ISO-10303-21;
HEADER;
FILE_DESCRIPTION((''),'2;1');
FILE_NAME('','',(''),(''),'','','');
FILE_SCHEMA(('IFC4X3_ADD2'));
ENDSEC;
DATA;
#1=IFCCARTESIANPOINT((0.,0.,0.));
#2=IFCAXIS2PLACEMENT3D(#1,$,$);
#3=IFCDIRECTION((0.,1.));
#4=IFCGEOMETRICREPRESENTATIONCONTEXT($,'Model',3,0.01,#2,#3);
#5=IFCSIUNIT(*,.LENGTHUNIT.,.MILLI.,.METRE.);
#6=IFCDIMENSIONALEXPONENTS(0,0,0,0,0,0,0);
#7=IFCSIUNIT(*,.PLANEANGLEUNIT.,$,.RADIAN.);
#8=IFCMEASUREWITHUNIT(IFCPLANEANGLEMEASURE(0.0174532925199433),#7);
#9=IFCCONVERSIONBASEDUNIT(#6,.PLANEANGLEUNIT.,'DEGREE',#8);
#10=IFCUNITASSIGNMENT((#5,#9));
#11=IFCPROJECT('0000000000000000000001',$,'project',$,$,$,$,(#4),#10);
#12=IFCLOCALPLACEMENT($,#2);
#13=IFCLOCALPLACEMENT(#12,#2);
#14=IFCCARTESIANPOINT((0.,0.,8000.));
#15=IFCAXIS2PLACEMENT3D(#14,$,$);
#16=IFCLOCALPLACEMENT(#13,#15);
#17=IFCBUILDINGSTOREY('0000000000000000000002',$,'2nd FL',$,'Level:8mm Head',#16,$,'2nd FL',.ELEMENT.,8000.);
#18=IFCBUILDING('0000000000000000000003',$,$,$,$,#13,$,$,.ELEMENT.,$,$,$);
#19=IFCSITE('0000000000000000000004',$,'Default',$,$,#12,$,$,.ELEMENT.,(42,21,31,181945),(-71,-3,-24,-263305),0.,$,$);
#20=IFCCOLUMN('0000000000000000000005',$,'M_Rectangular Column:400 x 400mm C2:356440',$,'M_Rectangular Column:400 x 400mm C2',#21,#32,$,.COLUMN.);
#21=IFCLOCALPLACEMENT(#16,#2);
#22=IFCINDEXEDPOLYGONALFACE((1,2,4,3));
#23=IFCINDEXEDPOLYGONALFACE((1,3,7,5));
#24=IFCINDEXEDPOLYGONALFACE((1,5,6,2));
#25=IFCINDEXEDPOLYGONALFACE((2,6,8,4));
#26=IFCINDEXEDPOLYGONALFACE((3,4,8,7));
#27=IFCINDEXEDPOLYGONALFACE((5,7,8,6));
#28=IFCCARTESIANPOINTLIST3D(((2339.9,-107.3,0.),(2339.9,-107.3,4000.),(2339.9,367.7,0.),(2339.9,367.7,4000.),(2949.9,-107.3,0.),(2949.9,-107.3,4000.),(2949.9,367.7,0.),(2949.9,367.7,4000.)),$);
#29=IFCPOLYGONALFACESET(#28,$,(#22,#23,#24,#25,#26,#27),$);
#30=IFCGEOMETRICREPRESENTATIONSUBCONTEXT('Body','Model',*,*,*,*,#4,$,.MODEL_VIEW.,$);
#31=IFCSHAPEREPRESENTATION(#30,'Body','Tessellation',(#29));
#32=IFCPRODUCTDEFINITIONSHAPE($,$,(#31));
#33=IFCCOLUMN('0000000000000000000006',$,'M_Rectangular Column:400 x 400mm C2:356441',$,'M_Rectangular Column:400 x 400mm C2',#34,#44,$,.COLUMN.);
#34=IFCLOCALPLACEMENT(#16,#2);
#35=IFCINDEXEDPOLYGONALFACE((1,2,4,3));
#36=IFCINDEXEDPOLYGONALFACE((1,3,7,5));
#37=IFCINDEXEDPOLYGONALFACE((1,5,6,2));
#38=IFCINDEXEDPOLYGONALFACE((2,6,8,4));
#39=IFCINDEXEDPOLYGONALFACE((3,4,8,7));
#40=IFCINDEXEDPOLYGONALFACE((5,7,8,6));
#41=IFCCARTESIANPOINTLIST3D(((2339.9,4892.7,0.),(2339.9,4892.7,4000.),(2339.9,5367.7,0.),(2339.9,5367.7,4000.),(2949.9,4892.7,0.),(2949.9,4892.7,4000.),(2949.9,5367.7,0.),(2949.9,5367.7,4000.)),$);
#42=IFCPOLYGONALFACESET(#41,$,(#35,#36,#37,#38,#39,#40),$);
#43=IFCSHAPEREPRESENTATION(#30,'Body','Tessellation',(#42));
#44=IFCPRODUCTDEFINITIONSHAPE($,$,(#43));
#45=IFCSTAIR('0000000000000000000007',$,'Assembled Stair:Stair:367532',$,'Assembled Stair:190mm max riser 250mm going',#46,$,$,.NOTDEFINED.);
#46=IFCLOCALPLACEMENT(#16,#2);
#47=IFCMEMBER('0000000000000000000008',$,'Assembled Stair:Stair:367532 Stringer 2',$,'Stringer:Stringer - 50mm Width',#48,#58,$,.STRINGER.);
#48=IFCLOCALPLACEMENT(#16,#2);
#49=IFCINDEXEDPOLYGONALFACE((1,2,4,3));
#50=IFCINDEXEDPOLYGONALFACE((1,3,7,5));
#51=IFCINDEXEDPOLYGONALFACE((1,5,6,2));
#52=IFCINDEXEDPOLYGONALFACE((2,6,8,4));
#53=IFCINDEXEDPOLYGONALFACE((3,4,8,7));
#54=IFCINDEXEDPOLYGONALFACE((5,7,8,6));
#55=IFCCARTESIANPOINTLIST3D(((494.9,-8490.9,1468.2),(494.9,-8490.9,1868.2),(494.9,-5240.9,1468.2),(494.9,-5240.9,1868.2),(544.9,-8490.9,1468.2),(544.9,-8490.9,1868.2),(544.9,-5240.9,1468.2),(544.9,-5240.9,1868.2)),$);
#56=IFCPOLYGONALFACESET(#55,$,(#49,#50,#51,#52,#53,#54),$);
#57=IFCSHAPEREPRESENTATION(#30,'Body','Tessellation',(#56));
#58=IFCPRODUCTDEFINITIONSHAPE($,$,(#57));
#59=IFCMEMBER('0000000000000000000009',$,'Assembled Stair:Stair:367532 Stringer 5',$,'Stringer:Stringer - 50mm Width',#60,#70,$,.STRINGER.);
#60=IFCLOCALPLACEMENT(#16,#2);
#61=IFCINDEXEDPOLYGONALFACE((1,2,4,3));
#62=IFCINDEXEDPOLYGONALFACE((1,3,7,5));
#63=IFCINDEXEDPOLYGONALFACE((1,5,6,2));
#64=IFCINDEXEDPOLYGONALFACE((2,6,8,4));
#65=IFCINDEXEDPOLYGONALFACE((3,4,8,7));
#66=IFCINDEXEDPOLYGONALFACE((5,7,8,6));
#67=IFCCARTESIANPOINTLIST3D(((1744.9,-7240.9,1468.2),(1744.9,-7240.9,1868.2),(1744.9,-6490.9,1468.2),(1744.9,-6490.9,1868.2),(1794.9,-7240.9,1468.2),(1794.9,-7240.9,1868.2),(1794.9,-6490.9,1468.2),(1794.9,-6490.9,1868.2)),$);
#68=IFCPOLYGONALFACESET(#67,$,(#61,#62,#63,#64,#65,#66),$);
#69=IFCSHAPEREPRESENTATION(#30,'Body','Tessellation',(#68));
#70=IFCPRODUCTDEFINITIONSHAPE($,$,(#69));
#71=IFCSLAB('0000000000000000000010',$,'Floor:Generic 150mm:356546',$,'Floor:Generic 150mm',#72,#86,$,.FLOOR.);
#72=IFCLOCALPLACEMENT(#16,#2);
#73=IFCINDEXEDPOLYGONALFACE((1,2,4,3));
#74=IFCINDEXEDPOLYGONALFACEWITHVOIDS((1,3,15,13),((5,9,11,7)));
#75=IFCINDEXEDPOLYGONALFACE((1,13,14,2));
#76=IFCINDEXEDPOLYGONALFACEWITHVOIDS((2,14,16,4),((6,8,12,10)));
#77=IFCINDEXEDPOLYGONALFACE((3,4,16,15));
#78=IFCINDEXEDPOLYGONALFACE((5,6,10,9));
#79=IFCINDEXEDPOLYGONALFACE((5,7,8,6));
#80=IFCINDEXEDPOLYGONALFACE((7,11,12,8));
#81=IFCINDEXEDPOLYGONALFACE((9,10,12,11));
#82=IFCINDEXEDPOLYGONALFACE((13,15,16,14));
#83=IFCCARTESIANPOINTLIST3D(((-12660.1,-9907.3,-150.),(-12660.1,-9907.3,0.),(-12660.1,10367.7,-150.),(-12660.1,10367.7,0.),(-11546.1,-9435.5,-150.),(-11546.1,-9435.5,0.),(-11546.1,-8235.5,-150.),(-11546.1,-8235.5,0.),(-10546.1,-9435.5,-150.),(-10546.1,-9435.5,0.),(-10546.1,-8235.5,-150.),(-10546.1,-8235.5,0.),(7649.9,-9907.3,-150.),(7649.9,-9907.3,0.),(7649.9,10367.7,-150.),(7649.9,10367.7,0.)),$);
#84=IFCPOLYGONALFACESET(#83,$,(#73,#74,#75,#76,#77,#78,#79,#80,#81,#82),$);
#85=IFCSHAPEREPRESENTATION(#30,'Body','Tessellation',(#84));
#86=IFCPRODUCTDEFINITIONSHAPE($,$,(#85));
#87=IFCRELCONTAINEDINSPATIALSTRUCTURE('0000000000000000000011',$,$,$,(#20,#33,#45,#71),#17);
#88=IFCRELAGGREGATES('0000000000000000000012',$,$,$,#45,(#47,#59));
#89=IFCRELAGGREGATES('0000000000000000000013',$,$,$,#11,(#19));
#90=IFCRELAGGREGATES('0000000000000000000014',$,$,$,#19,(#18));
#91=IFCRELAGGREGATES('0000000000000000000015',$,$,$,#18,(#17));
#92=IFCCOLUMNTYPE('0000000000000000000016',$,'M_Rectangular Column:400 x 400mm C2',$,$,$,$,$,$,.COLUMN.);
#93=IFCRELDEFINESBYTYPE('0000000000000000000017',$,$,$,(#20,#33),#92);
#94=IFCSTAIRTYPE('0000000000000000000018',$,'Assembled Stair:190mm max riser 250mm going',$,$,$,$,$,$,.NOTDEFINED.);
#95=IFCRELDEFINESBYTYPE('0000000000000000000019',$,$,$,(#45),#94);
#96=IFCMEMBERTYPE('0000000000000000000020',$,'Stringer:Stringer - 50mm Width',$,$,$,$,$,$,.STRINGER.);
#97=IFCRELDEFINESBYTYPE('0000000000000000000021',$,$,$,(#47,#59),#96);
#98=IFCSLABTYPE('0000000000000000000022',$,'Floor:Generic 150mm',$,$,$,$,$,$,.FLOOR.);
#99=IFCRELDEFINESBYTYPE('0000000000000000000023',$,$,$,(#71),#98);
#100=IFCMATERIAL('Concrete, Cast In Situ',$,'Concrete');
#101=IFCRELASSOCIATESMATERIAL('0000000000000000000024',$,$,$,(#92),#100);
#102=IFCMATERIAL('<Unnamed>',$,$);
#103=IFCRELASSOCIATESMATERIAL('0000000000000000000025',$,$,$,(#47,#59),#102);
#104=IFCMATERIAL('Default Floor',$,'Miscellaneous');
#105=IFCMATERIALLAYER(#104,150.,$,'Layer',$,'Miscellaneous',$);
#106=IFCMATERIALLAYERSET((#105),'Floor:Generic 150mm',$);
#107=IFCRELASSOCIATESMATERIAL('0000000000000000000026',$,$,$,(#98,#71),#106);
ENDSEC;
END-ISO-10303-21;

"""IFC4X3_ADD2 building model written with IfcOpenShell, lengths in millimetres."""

from ifc_helpers import new_model, entity, si_unit, converted_unit, direction, frame, frame_2d, origin, origin_2d_with_axis, place, context, subcontext, project, spatial, rectangle, extrude, boolean, source, transform, mapped, material, layer, layer_set, layer_usage, material_profile, profile_set, type_object, type_shapes, element, aggregate, save


model = new_model("IFC4X3_ADD2")

# Units and contexts
model_context = context("Model", 3, precision=0.01, world=origin(), true_north=direction((0.0, 1.0)))
body_context = subcontext(model_context, "Body", "Model", "MODEL_VIEW")
ifc_project = project(units=[si_unit("LENGTHUNIT", "METRE", prefix="MILLI"), converted_unit("PLANEANGLEUNIT", "DEGREE", entity("IfcPlaneAngleMeasure", 0.0174532925199433), si_unit("PLANEANGLEUNIT", "RADIAN"), dimensions=[0, 0, 0, 0, 0, 0, 0])], contexts=[model_context])

# Site, building, storey
site_placement = place(None, origin())
site = spatial("IfcSite", under=ifc_project, at=site_placement, Name="Default", CompositionType="ELEMENT", RefLatitude=(42, 21, 31, 181945), RefLongitude=(-71, -3, -24, -263305), RefElevation=0.0)
building_placement = place(site_placement, origin())
building = spatial("IfcBuilding", under=site, at=building_placement, CompositionType="ELEMENT")
storey_placement = place(building_placement, frame((0.0, 0.0, 8000.0)))
storey = spatial("IfcBuildingStorey", under=building, at=storey_placement, Name="2nd FL", ObjectType="Level:8mm Head", LongName="2nd FL", CompositionType="ELEMENT", Elevation=8000.0)

# Columns
ifc_material_1 = material(Name="Concrete, Cast In Situ", Category="Concrete")
ifc_material_profile_1 = material_profile(ifc_material_1, rectangle(XDim=610.0, YDim=475.0, at=origin_2d_with_axis()), Name="400 x 400mm C2")
ifc_profile_set_1 = profile_set([ifc_material_profile_1], Name="400 x 400mm C2")
column_type_1 = type_object("IfcColumnType", Name="M_Rectangular Column:400 x 400mm C2", PredefinedType="COLUMN", material=ifc_profile_set_1)
shared_shape_1 = source(origin(), body_context, "Body", "SweptSolid", [
    extrude(rectangle(XDim=610.0, YDim=475.0, at=origin_2d_with_axis()), frame((0.0, 0.0, 8000.0), z_axis=(0.0, 0.0, 1.0), x_axis=(-1.0, 0.0, 0.0)), (0.0, 0.0, 1.0), 4000.0),
])
type_shapes(column_type_1, [shared_shape_1])
for number, where, name in (
    (1, (2644.9, 130.2, -8000.0), "M_Rectangular Column:400 x 400mm C2:356440"),
    (2, (2644.9, 5130.2, -8000.0), "M_Rectangular Column:400 x 400mm C2:356441"),
):
    element("IfcColumn", number, at=place(storey_placement, frame(where)), inside=storey, type_object=column_type_1, Name=name, ObjectType="M_Rectangular Column:400 x 400mm C2", PredefinedType="COLUMN", context=body_context, shape_type="MappedRepresentation", body=[
        mapped(shared_shape_1, transform((0.0, 0.0, 0.0), scale=1.0)),
    ])

# Stair, members
stair_type = type_object("IfcStairType", Name="Assembled Stair:190mm max riser 250mm going", PredefinedType="NOTDEFINED")
stair_placement = place(storey_placement, origin())
stair = element("IfcStair", 3, at=stair_placement, inside=storey, type_object=stair_type, Name="Assembled Stair:Stair:367532", ObjectType="Assembled Stair:190mm max riser 250mm going", PredefinedType="NOTDEFINED")
ifc_material_2 = material(Name="<Unnamed>")
member_type = type_object("IfcMemberType", Name="Stringer:Stringer - 50mm Width", PredefinedType="STRINGER")
member_1_placement = place(stair_placement, frame((494.9, -8490.9, 1468.2)))
member_1 = element("IfcMember", 4, at=member_1_placement, type_object=member_type, material=ifc_material_2, Name="Assembled Stair:Stair:367532 Stringer 2", ObjectType="Stringer:Stringer - 50mm Width", PredefinedType="STRINGER", context=body_context, shape_type="SweptSolid", body=[
    extrude(rectangle(XDim=3250.0, YDim=50.0, at=origin_2d_with_axis()), frame((25.0, 1625.0, 0.0), z_axis=(0.0, 0.0, 1.0), x_axis=(0.0, 1.0, 0.0)), (0.0, 0.0, 1.0), 400.0),
])
member_2_placement = place(stair_placement, frame((1744.9, -7240.9, 1468.2)))
member_2 = element("IfcMember", 5, at=member_2_placement, type_object=member_type, material=ifc_material_2, Name="Assembled Stair:Stair:367532 Stringer 5", ObjectType="Stringer:Stringer - 50mm Width", PredefinedType="STRINGER", context=body_context, shape_type="SweptSolid", body=[
    extrude(rectangle(XDim=750.0, YDim=50.0, at=frame_2d((0.0, 0.0), x_axis=(1.0, 0.0))), frame((25.0, 375.0, 0.0), z_axis=(0.0, 0.0, 1.0), x_axis=(0.0, 1.0, 0.0)), (0.0, 0.0, 1.0), 400.0),
])

# Slab, opening
ifc_material_3 = material(Name="Default Floor", Category="Miscellaneous")
ifc_layer = layer(ifc_material_3, 150.0, Name="Layer", Category="Miscellaneous")
ifc_layer_set = layer_set([ifc_layer], Name="Floor:Generic 150mm")
ifc_layer_usage = layer_usage(ifc_layer_set, "AXIS3", "POSITIVE", 0.0)
slab_type = type_object("IfcSlabType", Name="Floor:Generic 150mm", PredefinedType="FLOOR", material=ifc_layer_set)
slab_placement = place(storey_placement, origin())
slab = element("IfcSlab", 6, at=slab_placement, inside=storey, type_object=slab_type, material=ifc_layer_usage, Name="Floor:Generic 150mm:356546", ObjectType="Floor:Generic 150mm", PredefinedType="FLOOR", context=body_context, shape_type="SweptSolid", body=[
    boolean("DIFFERENCE", extrude(rectangle(XDim=20275.0, YDim=20310.0, at=origin_2d_with_axis()), frame((-2505.1, 230.2, 0.0), z_axis=(0.0, 0.0, -1.0), x_axis=(0.0, 1.0, 0.0)), (0.0, 0.0, 1.0), 150.0), extrude(rectangle(XDim=1200.0, YDim=1000.0, at=frame_2d((0.0, 0.0), x_axis=(1.0, 0.0))), frame((-11046.1, -8835.5, 0.0), z_axis=(0.0, 0.0, -1.0), x_axis=(0.0, -1.0, 0.0)), (0.0, 0.0, 1.0), 150.0)),
])
opening_placement = place(slab_placement, origin())
element("IfcOpeningElement", 7, at=opening_placement, cuts=slab, PredefinedType="OPENING", context=body_context, shape_type="SweptSolid", body=[
    extrude(rectangle(XDim=1200.0, YDim=1000.0, at=frame_2d((0.0, 0.0), x_axis=(1.0, 0.0))), frame((-11046.1, -8835.5, -150.0), z_axis=(0.0, 0.0, 1.0), x_axis=(0.0, 1.0, 0.0)), (0.0, 0.0, 1.0), 150.0),
])

aggregate(stair, [member_1, member_2])

save(model, "model.ifc")
